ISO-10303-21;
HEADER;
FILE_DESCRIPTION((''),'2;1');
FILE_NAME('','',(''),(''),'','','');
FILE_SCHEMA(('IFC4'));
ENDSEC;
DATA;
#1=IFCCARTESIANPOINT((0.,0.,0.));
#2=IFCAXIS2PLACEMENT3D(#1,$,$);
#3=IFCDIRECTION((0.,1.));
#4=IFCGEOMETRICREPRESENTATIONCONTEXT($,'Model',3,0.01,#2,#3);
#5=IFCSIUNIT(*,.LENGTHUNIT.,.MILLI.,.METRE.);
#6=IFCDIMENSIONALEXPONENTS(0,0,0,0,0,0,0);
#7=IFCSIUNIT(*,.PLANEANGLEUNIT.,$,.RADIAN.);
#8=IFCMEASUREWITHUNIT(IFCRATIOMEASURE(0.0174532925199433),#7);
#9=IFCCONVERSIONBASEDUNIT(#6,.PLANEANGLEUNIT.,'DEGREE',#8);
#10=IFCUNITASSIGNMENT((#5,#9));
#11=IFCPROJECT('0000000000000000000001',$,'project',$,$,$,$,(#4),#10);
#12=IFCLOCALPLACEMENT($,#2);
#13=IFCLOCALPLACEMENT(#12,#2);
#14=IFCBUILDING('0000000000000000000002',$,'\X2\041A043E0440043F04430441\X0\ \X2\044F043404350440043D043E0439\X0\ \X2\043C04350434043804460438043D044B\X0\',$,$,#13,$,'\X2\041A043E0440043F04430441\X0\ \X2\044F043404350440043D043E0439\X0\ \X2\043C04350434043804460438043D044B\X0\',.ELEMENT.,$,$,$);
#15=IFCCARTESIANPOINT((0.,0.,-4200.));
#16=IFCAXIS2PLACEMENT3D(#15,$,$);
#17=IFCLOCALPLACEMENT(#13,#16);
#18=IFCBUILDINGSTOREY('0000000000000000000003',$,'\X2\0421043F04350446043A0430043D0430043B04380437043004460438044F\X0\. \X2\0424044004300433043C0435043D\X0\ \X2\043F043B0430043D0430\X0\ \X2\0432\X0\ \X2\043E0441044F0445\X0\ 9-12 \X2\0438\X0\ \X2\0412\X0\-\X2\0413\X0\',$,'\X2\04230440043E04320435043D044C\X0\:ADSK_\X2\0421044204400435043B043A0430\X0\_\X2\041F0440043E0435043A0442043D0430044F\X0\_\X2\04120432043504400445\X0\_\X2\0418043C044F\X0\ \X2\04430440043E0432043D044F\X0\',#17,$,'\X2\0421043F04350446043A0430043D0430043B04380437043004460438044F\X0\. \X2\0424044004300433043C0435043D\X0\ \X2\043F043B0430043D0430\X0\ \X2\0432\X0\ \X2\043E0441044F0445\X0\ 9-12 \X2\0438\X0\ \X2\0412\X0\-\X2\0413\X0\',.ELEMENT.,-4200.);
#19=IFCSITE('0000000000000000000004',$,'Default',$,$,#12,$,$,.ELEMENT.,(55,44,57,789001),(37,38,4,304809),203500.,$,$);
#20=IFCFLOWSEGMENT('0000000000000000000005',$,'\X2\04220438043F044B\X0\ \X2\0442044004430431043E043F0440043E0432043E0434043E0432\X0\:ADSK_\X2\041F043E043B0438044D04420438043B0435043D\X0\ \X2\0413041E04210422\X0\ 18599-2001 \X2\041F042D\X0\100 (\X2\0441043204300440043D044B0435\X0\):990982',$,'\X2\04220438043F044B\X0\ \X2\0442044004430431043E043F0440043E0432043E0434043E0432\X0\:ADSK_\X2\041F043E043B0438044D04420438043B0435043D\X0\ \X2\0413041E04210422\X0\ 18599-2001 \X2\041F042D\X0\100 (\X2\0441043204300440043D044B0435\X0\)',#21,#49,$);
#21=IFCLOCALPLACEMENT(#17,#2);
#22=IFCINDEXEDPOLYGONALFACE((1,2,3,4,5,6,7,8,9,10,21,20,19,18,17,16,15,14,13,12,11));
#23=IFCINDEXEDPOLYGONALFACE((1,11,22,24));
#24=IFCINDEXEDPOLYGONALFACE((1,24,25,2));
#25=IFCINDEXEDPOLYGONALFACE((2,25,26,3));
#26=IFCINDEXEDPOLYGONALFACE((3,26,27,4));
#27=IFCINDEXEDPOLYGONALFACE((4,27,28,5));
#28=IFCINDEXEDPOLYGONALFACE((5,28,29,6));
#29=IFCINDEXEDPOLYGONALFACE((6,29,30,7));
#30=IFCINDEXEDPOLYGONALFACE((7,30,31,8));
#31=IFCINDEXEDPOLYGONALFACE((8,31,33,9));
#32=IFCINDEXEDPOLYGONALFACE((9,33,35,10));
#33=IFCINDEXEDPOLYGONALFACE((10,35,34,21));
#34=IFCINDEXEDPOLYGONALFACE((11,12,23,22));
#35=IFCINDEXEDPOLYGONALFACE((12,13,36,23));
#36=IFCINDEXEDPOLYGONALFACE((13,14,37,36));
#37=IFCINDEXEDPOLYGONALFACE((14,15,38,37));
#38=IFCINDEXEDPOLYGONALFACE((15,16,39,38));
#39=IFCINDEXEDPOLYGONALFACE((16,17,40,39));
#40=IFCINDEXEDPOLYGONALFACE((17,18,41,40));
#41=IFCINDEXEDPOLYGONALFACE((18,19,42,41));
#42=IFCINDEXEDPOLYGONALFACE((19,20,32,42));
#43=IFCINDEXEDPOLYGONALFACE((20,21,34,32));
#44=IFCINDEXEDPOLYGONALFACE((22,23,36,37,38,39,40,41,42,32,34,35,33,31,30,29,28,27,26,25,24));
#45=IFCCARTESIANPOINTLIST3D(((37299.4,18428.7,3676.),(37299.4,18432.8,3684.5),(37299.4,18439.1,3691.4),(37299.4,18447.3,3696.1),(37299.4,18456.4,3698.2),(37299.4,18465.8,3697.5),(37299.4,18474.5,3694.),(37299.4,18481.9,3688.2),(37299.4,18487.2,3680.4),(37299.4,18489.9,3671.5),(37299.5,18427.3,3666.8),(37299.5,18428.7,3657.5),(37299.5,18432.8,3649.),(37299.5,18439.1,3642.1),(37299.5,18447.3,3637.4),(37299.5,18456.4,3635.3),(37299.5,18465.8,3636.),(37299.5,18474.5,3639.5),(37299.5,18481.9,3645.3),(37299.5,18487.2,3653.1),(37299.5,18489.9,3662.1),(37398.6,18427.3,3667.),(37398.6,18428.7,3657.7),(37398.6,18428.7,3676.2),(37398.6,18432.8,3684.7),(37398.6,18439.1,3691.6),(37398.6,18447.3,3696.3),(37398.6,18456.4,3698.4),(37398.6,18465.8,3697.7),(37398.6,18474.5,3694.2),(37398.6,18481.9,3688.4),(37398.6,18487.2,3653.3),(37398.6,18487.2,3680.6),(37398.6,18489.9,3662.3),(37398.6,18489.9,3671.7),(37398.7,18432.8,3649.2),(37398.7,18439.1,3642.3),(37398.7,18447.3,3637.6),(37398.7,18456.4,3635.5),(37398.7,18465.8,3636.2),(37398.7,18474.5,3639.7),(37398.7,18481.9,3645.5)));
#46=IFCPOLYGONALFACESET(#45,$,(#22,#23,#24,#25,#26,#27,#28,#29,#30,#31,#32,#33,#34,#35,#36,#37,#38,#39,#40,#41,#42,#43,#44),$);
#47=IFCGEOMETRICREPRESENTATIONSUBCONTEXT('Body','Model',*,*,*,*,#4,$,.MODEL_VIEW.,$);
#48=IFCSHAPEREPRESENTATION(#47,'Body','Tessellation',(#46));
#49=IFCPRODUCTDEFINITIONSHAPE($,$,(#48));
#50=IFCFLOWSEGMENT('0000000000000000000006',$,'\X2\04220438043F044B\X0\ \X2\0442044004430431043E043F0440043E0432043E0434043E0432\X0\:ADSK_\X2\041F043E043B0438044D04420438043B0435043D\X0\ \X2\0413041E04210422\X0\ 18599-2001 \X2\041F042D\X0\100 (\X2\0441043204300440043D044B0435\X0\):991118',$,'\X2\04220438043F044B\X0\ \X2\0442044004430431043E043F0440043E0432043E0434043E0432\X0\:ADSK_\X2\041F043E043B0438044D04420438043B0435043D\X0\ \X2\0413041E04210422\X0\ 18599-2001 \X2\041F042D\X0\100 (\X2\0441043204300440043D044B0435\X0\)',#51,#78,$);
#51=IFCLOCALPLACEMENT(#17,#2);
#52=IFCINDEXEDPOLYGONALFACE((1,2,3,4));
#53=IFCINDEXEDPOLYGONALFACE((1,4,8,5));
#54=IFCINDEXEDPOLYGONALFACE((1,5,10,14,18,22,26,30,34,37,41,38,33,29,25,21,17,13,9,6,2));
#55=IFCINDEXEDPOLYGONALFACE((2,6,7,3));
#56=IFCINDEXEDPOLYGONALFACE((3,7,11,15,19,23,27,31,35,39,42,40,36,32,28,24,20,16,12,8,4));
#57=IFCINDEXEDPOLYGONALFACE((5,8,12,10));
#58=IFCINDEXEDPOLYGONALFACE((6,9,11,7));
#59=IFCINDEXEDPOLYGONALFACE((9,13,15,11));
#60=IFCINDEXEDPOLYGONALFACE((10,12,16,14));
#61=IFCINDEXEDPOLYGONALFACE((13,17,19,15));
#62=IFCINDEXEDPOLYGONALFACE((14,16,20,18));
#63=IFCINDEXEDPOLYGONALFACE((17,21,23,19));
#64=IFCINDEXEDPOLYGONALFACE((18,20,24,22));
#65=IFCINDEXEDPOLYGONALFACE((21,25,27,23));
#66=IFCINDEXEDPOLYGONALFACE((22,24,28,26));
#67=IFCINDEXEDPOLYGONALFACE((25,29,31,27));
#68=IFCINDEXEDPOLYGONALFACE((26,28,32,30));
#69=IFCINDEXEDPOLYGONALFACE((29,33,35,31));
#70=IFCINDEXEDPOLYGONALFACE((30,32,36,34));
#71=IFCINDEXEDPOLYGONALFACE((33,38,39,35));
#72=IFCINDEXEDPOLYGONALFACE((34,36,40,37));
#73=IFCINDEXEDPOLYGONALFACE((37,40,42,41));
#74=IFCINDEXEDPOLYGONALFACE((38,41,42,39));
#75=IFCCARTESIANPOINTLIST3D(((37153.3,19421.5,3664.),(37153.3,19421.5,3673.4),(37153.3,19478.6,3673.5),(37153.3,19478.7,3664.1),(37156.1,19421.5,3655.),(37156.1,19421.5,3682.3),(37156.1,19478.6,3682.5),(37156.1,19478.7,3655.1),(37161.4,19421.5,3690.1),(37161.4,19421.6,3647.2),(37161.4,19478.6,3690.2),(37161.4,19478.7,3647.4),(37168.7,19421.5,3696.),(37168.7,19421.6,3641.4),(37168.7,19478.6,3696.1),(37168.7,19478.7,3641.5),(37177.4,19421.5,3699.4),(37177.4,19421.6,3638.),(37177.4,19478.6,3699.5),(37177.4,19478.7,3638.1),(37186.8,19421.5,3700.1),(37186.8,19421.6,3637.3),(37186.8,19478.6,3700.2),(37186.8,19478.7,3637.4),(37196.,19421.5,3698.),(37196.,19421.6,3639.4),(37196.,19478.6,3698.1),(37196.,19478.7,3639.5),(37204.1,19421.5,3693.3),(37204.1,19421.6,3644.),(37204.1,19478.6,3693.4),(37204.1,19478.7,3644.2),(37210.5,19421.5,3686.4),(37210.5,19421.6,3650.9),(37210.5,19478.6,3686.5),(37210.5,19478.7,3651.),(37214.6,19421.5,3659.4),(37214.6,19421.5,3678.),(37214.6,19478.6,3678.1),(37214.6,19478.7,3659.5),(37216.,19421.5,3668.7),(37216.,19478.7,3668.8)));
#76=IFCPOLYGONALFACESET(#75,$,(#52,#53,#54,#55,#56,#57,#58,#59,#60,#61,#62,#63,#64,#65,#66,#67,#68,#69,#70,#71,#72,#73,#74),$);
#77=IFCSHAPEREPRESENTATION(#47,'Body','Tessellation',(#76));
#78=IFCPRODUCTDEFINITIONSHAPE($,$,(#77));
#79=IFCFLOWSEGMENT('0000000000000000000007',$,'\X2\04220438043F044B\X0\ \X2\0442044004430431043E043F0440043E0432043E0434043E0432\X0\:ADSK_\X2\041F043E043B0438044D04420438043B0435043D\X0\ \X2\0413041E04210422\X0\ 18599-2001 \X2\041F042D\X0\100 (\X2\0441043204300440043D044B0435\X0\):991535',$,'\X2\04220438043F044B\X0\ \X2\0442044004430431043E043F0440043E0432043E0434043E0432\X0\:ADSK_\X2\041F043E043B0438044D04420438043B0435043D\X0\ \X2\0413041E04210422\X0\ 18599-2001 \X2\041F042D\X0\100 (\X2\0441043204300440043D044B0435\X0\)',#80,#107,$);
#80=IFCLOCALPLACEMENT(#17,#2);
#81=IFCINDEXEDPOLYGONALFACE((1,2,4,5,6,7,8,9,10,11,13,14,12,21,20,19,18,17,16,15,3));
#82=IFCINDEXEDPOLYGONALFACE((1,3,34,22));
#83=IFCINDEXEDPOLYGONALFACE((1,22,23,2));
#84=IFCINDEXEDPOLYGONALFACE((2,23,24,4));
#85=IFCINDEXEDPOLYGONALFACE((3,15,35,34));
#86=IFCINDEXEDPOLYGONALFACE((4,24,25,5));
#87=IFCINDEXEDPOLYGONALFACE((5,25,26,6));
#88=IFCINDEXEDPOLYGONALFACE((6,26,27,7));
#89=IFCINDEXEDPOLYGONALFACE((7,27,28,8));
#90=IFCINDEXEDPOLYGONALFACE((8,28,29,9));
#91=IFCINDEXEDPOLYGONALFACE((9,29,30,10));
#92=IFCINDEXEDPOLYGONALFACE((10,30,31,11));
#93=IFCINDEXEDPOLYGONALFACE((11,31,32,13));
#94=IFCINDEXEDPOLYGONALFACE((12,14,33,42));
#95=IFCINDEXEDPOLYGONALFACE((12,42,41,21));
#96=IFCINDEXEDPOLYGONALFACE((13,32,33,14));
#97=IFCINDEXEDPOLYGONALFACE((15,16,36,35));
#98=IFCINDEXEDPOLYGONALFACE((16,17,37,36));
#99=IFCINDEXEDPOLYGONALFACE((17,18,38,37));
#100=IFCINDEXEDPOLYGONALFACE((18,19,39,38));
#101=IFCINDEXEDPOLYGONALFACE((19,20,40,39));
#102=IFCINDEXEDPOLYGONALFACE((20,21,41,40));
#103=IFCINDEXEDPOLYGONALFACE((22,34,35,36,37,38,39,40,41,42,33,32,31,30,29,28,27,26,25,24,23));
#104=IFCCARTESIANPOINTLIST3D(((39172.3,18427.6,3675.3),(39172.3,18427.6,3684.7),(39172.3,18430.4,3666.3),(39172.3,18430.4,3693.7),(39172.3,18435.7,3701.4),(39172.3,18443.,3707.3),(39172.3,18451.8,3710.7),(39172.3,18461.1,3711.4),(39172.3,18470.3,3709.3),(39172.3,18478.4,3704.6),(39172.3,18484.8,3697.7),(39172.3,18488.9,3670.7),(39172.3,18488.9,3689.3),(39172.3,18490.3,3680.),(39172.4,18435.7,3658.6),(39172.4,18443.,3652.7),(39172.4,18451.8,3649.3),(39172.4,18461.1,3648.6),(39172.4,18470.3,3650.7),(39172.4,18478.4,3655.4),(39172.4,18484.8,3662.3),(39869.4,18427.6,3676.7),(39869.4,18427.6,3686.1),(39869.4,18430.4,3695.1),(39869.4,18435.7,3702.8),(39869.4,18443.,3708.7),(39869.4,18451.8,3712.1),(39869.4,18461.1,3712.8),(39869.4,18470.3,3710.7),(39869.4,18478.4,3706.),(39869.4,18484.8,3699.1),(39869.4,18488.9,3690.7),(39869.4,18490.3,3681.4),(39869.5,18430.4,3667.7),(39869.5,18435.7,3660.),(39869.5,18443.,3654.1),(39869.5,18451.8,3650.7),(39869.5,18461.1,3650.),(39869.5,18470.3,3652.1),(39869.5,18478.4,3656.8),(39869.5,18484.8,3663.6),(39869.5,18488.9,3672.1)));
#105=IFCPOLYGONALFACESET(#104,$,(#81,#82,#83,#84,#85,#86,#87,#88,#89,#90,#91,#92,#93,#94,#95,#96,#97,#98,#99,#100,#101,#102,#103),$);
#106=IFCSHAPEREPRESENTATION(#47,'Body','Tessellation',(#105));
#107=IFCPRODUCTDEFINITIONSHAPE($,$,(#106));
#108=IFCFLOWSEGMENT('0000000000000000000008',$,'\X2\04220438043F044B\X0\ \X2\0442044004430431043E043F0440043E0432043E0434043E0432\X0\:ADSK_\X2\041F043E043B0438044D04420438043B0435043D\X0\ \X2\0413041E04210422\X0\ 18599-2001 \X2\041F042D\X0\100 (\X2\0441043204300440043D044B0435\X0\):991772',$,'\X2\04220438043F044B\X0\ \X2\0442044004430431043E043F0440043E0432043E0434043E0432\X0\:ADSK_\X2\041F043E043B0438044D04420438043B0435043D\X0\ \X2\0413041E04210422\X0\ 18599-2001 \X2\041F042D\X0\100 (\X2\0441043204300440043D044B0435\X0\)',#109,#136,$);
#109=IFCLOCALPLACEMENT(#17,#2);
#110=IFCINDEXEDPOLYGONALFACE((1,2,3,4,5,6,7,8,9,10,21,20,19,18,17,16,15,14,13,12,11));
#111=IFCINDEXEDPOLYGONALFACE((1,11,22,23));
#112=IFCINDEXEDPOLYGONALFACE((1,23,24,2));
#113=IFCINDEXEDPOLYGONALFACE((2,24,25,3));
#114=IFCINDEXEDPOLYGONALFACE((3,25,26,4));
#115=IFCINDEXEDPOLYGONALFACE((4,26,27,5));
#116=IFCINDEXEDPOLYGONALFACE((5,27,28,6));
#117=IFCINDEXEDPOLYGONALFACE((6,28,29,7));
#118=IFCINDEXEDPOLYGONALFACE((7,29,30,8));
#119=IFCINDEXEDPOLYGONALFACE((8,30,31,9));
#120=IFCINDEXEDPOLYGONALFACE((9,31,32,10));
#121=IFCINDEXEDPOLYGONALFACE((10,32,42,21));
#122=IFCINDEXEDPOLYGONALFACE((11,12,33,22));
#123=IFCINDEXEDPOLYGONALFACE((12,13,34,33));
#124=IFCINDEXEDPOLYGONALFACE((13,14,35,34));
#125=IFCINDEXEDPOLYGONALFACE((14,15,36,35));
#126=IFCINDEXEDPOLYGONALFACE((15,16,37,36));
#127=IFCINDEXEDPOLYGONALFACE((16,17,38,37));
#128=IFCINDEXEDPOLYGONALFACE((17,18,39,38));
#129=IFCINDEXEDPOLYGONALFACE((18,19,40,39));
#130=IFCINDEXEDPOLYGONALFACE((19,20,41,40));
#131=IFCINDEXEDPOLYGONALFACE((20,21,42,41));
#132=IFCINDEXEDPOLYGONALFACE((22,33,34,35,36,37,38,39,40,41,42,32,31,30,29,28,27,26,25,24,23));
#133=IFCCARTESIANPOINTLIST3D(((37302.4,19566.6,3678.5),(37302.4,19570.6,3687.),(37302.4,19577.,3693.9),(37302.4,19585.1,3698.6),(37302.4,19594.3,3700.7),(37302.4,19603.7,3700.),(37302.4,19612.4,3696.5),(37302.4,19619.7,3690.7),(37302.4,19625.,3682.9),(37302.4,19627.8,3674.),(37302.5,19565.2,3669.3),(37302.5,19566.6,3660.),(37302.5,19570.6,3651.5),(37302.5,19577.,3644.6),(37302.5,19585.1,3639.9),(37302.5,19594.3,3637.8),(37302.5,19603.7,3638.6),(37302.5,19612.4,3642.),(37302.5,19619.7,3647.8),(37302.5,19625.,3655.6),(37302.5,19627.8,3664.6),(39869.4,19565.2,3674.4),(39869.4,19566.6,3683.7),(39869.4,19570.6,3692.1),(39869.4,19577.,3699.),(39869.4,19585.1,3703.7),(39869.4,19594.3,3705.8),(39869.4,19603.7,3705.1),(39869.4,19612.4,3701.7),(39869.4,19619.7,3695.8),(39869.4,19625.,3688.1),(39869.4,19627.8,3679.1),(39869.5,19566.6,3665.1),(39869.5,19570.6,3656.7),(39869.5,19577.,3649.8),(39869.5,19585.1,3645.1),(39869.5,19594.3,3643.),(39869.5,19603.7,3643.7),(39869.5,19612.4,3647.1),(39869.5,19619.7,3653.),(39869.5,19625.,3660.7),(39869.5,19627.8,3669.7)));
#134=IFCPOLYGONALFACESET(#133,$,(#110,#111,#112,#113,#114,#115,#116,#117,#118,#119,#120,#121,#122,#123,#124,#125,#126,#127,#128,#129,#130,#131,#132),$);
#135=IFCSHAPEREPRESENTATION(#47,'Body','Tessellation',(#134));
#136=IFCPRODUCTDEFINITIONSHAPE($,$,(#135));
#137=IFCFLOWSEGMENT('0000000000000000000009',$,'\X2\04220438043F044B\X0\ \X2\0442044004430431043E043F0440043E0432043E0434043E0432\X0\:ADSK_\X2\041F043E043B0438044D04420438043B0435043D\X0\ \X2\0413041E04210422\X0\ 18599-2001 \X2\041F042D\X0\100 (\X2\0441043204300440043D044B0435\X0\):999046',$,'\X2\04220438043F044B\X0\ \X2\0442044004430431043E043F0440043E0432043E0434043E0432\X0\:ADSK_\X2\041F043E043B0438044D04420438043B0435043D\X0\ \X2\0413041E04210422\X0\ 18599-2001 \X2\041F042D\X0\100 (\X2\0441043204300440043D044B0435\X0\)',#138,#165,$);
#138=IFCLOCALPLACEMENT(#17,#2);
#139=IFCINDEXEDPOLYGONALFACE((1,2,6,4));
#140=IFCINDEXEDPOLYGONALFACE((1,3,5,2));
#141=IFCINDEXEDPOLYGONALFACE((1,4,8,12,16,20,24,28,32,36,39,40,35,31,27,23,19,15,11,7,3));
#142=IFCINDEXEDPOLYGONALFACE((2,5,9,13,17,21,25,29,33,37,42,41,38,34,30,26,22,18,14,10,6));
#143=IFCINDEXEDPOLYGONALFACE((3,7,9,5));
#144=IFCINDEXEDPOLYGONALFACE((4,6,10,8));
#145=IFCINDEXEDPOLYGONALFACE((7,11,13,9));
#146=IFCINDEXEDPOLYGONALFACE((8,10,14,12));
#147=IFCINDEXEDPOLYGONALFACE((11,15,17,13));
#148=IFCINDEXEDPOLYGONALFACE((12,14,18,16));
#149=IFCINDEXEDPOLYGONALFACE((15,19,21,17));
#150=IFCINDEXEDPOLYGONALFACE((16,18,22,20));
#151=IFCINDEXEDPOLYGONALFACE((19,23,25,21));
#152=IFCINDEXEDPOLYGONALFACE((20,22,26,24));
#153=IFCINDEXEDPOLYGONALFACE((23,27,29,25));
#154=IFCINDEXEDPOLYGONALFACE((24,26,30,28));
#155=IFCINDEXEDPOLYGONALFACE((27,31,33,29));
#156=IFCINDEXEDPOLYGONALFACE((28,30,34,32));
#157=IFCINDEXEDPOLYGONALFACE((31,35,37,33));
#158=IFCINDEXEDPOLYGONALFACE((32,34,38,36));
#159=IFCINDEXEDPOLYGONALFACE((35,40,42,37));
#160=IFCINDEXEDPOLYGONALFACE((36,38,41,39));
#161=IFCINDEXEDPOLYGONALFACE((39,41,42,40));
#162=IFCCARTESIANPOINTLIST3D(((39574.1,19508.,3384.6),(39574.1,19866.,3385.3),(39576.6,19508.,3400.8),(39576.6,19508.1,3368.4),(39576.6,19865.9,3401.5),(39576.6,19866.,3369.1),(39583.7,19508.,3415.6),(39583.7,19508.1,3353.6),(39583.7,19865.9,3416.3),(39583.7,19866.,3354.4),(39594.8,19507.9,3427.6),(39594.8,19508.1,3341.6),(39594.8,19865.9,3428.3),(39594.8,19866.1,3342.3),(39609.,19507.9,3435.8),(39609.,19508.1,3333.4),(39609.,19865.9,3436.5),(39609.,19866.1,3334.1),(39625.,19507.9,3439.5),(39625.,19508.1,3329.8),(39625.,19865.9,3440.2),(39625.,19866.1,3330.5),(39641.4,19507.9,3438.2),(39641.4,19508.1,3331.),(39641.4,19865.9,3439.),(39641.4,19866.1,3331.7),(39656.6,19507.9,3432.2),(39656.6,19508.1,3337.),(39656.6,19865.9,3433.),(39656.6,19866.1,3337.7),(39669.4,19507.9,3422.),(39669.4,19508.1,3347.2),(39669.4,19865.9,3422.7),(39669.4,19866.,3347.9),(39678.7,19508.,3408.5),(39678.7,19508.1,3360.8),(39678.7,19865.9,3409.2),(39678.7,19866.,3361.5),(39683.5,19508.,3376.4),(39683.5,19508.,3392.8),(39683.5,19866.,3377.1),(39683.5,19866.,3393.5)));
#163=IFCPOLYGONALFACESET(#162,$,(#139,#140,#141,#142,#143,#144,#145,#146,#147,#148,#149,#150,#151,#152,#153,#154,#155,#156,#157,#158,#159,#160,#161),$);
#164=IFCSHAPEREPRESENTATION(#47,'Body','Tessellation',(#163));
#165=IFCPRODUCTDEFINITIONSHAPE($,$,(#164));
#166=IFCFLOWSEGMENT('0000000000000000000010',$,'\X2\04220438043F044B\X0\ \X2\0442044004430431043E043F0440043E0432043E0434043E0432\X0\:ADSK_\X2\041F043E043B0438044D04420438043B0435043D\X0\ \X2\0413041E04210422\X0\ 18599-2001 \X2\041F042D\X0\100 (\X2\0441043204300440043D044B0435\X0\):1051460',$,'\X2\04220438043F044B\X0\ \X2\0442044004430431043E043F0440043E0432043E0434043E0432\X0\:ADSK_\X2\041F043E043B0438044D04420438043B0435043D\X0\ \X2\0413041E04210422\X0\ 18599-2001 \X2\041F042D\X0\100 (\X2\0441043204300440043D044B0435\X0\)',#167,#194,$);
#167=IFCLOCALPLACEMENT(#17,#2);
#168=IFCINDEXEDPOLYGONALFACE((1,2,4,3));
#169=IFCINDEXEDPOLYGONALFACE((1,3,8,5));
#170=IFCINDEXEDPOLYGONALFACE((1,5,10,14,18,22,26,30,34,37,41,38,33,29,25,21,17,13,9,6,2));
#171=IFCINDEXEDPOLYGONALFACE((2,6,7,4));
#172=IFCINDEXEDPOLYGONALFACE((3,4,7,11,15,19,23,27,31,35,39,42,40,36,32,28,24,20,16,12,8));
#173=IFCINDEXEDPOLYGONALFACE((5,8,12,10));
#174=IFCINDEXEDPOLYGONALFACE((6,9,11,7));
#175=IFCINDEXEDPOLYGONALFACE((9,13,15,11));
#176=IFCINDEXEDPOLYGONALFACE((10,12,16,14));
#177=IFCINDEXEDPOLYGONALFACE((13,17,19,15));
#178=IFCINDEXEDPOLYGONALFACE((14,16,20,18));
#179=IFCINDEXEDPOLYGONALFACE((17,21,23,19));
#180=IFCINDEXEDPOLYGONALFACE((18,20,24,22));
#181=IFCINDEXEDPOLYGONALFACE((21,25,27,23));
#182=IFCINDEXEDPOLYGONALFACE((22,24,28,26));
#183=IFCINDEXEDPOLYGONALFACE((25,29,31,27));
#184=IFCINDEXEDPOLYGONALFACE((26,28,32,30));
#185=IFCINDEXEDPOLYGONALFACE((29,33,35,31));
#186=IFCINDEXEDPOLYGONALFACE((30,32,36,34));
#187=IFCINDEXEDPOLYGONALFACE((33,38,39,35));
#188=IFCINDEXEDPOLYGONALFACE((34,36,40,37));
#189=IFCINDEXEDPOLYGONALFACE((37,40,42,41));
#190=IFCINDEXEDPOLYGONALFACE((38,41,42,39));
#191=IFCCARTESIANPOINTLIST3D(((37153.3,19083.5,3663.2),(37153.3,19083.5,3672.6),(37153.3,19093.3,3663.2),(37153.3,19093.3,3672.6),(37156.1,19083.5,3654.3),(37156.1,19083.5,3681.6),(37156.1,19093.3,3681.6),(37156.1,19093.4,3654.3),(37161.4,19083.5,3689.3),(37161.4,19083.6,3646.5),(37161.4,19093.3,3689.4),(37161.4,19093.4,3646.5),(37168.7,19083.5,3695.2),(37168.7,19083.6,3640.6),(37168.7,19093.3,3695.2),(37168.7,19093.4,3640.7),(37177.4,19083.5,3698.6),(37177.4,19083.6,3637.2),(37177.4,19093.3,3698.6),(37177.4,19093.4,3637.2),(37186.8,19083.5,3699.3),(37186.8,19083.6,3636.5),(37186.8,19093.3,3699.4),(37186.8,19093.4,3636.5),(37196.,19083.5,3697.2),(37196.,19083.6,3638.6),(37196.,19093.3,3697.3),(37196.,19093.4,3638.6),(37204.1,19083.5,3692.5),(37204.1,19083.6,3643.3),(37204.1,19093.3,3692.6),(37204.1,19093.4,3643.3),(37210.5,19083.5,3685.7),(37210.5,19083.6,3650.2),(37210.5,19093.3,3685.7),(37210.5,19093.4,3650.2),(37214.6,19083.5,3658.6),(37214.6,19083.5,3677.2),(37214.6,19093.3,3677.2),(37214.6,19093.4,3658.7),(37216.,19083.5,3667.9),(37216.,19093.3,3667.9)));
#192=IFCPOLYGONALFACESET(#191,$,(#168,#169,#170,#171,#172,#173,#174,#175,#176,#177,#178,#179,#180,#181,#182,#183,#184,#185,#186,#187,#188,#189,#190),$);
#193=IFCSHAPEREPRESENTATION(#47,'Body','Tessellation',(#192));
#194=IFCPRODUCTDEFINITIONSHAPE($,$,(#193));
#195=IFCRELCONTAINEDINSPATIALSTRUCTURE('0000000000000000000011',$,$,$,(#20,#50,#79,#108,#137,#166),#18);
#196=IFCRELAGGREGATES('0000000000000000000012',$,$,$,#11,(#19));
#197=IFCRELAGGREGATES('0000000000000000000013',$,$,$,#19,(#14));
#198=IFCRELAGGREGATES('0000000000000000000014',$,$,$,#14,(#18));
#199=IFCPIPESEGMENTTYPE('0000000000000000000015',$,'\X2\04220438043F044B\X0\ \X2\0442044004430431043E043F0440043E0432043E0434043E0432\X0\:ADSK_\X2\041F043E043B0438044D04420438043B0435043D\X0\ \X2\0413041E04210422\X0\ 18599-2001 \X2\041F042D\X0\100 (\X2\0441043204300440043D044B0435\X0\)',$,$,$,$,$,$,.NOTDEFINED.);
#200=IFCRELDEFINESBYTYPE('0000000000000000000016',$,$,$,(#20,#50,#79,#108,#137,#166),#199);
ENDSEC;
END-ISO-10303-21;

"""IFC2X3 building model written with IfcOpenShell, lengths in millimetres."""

from ifc_helpers import new_model, entity, si_unit, converted_unit, direction, frame, frame_2d, origin, origin_2d_with_axis, place, context, subcontext, project, spatial, circle, extrude, type_object, element, save


model = new_model("IFC2X3")

# Units and contexts
model_context = context("Model", 3, precision=0.01, world=origin(), true_north=direction((0.0, 1.0)))
body_context = subcontext(model_context, "Body", "Model", "MODEL_VIEW")
ifc_project = project(units=[si_unit("LENGTHUNIT", "METRE", prefix="MILLI"), converted_unit("PLANEANGLEUNIT", "DEGREE", entity("IfcRatioMeasure", 0.0174532925199433), si_unit("PLANEANGLEUNIT", "RADIAN"), dimensions=[0, 0, 0, 0, 0, 0, 0])], contexts=[model_context])

# Site, building, storey
site_placement = place(None, frame((0.0, 0.0, 0.0)))
site = spatial("IfcSite", under=ifc_project, at=site_placement, Name="Default", CompositionType="ELEMENT", RefLatitude=(55, 44, 57, 789001), RefLongitude=(37, 38, 4, 304809), RefElevation=203500.0)
building_placement = place(site_placement, origin())
building = spatial("IfcBuilding", under=site, at=building_placement, Name="Корпус ядерной медицины", LongName="Корпус ядерной медицины", CompositionType="ELEMENT")
storey_placement = place(building_placement, frame((0.0, 0.0, -4200.0)))
storey = spatial("IfcBuildingStorey", under=building, at=storey_placement, Name="Спецканализация. Фрагмен плана в осях 9-12 и В-Г", ObjectType="Уровень:ADSK_Стрелка_Проектная_Вверх_Имя уровня", LongName="Спецканализация. Фрагмен плана в осях 9-12 и В-Г", CompositionType="ELEMENT", Elevation=-4200.0)

# Flow segments
pipe_segment_type = type_object("IfcPipeSegmentType", Name="Типы трубопроводов:ADSK_Полиэтилен ГОСТ 18599-2001 ПЭ100 (сварные)", PredefinedType="NOTDEFINED")
flow_segment_1_placement = place(storey_placement, frame((37299.4, 18425.7, 3633.7)))
element("IfcFlowSegment", 1, at=flow_segment_1_placement, inside=storey, type_object=pipe_segment_type, Name="Типы трубопроводов:ADSK_Полиэтилен ГОСТ 18599-2001 ПЭ100 (сварные):990982", ObjectType="Типы трубопроводов:ADSK_Полиэтилен ГОСТ 18599-2001 ПЭ100 (сварные)", context=body_context, shape_type="SweptSolid", body=[
    extrude(circle(Radius=31.5, at=origin_2d_with_axis()), frame((0.1, 33.1, 33.1), z_axis=(0.999998, 0.0, 0.001997), x_axis=(0.0, -1.0, 0.0)), (0.0, 0.0, 1.0), 99.2),
])
flow_segment_2_placement = place(storey_placement, frame((37151.4, 19421.5, 3635.6)))
element("IfcFlowSegment", 2, at=flow_segment_2_placement, inside=storey, type_object=pipe_segment_type, Name="Типы трубопроводов:ADSK_Полиэтилен ГОСТ 18599-2001 ПЭ100 (сварные):991118", ObjectType="Типы трубопроводов:ADSK_Полиэтилен ГОСТ 18599-2001 ПЭ100 (сварные)", context=body_context, shape_type="SweptSolid", body=[
    extrude(circle(Radius=31.5, at=origin_2d_with_axis()), frame((33.1, 0.1, 33.1), z_axis=(0.0, 0.999998, 0.002007), x_axis=(1.0, 0.0, 0.0)), (0.0, 0.0, 1.0), 57.1),
])
flow_segment_3_placement = place(storey_placement, frame((39172.3, 18425.7, 3646.9)))
element("IfcFlowSegment", 3, at=flow_segment_3_placement, inside=storey, type_object=pipe_segment_type, Name="Типы трубопроводов:ADSK_Полиэтилен ГОСТ 18599-2001 ПЭ100 (сварные):991535", ObjectType="Типы трубопроводов:ADSK_Полиэтилен ГОСТ 18599-2001 ПЭ100 (сварные)", context=body_context, shape_type="SweptSolid", body=[
    extrude(circle(Radius=31.5, at=origin_2d_with_axis()), frame((0.1, 33.1, 33.1), z_axis=(0.999998, 0.0, 0.001997), x_axis=(0.0, 1.0, 0.0)), (0.0, 0.0, 1.0), 697.1),
])
flow_segment_4_placement = place(storey_placement, frame((37302.4, 19563.6, 3636.2)))
element("IfcFlowSegment", 4, at=flow_segment_4_placement, inside=storey, type_object=pipe_segment_type, Name="Типы трубопроводов:ADSK_Полиэтилен ГОСТ 18599-2001 ПЭ100 (сварные):991772", ObjectType="Типы трубопроводов:ADSK_Полиэтилен ГОСТ 18599-2001 ПЭ100 (сварные)", context=body_context, shape_type="SweptSolid", body=[
    extrude(circle(Radius=31.5, at=origin_2d_with_axis()), frame((0.1, 33.1, 33.1), z_axis=(0.999998, 0.0, 0.002), x_axis=(0.0, -1.0, 0.0)), (0.0, 0.0, 1.0), 2567.0),
])
flow_segment_5_placement = place(storey_placement, frame((39572.5, 19507.9, 3328.0)))
element("IfcFlowSegment", 5, at=flow_segment_5_placement, inside=storey, type_object=pipe_segment_type, Name="Типы трубопроводов:ADSK_Полиэтилен ГОСТ 18599-2001 ПЭ100 (сварные):999046", ObjectType="Типы трубопроводов:ADSK_Полиэтилен ГОСТ 18599-2001 ПЭ100 (сварные)", context=body_context, shape_type="SweptSolid", body=[
    extrude(circle(Radius=55.0, at=frame_2d((0.0, 0.0), x_axis=(1.0, 0.0))), frame((56.6, 0.1, 56.6), z_axis=(-0.000004, 0.999998, 0.002), x_axis=(-1.0, -0.000004, 0.0)), (0.0, 0.0, 1.0), 358.0),
])
flow_segment_6_placement = place(storey_placement, frame((37151.4, 19083.5, 3634.8)))
element("IfcFlowSegment", 6, at=flow_segment_6_placement, inside=storey, type_object=pipe_segment_type, Name="Типы трубопроводов:ADSK_Полиэтилен ГОСТ 18599-2001 ПЭ100 (сварные):1051460", ObjectType="Типы трубопроводов:ADSK_Полиэтилен ГОСТ 18599-2001 ПЭ100 (сварные)", context=body_context, shape_type="SweptSolid", body=[
    extrude(circle(Radius=31.5, at=frame_2d((0.0, 0.0), x_axis=(1.0, 0.0))), frame((33.1, 0.1, 33.1), z_axis=(0.000001, 0.999998, 0.002), x_axis=(1.0, -0.000001, 0.0)), (0.0, 0.0, 1.0), 9.8),
])

save(model, "model.ifc")
